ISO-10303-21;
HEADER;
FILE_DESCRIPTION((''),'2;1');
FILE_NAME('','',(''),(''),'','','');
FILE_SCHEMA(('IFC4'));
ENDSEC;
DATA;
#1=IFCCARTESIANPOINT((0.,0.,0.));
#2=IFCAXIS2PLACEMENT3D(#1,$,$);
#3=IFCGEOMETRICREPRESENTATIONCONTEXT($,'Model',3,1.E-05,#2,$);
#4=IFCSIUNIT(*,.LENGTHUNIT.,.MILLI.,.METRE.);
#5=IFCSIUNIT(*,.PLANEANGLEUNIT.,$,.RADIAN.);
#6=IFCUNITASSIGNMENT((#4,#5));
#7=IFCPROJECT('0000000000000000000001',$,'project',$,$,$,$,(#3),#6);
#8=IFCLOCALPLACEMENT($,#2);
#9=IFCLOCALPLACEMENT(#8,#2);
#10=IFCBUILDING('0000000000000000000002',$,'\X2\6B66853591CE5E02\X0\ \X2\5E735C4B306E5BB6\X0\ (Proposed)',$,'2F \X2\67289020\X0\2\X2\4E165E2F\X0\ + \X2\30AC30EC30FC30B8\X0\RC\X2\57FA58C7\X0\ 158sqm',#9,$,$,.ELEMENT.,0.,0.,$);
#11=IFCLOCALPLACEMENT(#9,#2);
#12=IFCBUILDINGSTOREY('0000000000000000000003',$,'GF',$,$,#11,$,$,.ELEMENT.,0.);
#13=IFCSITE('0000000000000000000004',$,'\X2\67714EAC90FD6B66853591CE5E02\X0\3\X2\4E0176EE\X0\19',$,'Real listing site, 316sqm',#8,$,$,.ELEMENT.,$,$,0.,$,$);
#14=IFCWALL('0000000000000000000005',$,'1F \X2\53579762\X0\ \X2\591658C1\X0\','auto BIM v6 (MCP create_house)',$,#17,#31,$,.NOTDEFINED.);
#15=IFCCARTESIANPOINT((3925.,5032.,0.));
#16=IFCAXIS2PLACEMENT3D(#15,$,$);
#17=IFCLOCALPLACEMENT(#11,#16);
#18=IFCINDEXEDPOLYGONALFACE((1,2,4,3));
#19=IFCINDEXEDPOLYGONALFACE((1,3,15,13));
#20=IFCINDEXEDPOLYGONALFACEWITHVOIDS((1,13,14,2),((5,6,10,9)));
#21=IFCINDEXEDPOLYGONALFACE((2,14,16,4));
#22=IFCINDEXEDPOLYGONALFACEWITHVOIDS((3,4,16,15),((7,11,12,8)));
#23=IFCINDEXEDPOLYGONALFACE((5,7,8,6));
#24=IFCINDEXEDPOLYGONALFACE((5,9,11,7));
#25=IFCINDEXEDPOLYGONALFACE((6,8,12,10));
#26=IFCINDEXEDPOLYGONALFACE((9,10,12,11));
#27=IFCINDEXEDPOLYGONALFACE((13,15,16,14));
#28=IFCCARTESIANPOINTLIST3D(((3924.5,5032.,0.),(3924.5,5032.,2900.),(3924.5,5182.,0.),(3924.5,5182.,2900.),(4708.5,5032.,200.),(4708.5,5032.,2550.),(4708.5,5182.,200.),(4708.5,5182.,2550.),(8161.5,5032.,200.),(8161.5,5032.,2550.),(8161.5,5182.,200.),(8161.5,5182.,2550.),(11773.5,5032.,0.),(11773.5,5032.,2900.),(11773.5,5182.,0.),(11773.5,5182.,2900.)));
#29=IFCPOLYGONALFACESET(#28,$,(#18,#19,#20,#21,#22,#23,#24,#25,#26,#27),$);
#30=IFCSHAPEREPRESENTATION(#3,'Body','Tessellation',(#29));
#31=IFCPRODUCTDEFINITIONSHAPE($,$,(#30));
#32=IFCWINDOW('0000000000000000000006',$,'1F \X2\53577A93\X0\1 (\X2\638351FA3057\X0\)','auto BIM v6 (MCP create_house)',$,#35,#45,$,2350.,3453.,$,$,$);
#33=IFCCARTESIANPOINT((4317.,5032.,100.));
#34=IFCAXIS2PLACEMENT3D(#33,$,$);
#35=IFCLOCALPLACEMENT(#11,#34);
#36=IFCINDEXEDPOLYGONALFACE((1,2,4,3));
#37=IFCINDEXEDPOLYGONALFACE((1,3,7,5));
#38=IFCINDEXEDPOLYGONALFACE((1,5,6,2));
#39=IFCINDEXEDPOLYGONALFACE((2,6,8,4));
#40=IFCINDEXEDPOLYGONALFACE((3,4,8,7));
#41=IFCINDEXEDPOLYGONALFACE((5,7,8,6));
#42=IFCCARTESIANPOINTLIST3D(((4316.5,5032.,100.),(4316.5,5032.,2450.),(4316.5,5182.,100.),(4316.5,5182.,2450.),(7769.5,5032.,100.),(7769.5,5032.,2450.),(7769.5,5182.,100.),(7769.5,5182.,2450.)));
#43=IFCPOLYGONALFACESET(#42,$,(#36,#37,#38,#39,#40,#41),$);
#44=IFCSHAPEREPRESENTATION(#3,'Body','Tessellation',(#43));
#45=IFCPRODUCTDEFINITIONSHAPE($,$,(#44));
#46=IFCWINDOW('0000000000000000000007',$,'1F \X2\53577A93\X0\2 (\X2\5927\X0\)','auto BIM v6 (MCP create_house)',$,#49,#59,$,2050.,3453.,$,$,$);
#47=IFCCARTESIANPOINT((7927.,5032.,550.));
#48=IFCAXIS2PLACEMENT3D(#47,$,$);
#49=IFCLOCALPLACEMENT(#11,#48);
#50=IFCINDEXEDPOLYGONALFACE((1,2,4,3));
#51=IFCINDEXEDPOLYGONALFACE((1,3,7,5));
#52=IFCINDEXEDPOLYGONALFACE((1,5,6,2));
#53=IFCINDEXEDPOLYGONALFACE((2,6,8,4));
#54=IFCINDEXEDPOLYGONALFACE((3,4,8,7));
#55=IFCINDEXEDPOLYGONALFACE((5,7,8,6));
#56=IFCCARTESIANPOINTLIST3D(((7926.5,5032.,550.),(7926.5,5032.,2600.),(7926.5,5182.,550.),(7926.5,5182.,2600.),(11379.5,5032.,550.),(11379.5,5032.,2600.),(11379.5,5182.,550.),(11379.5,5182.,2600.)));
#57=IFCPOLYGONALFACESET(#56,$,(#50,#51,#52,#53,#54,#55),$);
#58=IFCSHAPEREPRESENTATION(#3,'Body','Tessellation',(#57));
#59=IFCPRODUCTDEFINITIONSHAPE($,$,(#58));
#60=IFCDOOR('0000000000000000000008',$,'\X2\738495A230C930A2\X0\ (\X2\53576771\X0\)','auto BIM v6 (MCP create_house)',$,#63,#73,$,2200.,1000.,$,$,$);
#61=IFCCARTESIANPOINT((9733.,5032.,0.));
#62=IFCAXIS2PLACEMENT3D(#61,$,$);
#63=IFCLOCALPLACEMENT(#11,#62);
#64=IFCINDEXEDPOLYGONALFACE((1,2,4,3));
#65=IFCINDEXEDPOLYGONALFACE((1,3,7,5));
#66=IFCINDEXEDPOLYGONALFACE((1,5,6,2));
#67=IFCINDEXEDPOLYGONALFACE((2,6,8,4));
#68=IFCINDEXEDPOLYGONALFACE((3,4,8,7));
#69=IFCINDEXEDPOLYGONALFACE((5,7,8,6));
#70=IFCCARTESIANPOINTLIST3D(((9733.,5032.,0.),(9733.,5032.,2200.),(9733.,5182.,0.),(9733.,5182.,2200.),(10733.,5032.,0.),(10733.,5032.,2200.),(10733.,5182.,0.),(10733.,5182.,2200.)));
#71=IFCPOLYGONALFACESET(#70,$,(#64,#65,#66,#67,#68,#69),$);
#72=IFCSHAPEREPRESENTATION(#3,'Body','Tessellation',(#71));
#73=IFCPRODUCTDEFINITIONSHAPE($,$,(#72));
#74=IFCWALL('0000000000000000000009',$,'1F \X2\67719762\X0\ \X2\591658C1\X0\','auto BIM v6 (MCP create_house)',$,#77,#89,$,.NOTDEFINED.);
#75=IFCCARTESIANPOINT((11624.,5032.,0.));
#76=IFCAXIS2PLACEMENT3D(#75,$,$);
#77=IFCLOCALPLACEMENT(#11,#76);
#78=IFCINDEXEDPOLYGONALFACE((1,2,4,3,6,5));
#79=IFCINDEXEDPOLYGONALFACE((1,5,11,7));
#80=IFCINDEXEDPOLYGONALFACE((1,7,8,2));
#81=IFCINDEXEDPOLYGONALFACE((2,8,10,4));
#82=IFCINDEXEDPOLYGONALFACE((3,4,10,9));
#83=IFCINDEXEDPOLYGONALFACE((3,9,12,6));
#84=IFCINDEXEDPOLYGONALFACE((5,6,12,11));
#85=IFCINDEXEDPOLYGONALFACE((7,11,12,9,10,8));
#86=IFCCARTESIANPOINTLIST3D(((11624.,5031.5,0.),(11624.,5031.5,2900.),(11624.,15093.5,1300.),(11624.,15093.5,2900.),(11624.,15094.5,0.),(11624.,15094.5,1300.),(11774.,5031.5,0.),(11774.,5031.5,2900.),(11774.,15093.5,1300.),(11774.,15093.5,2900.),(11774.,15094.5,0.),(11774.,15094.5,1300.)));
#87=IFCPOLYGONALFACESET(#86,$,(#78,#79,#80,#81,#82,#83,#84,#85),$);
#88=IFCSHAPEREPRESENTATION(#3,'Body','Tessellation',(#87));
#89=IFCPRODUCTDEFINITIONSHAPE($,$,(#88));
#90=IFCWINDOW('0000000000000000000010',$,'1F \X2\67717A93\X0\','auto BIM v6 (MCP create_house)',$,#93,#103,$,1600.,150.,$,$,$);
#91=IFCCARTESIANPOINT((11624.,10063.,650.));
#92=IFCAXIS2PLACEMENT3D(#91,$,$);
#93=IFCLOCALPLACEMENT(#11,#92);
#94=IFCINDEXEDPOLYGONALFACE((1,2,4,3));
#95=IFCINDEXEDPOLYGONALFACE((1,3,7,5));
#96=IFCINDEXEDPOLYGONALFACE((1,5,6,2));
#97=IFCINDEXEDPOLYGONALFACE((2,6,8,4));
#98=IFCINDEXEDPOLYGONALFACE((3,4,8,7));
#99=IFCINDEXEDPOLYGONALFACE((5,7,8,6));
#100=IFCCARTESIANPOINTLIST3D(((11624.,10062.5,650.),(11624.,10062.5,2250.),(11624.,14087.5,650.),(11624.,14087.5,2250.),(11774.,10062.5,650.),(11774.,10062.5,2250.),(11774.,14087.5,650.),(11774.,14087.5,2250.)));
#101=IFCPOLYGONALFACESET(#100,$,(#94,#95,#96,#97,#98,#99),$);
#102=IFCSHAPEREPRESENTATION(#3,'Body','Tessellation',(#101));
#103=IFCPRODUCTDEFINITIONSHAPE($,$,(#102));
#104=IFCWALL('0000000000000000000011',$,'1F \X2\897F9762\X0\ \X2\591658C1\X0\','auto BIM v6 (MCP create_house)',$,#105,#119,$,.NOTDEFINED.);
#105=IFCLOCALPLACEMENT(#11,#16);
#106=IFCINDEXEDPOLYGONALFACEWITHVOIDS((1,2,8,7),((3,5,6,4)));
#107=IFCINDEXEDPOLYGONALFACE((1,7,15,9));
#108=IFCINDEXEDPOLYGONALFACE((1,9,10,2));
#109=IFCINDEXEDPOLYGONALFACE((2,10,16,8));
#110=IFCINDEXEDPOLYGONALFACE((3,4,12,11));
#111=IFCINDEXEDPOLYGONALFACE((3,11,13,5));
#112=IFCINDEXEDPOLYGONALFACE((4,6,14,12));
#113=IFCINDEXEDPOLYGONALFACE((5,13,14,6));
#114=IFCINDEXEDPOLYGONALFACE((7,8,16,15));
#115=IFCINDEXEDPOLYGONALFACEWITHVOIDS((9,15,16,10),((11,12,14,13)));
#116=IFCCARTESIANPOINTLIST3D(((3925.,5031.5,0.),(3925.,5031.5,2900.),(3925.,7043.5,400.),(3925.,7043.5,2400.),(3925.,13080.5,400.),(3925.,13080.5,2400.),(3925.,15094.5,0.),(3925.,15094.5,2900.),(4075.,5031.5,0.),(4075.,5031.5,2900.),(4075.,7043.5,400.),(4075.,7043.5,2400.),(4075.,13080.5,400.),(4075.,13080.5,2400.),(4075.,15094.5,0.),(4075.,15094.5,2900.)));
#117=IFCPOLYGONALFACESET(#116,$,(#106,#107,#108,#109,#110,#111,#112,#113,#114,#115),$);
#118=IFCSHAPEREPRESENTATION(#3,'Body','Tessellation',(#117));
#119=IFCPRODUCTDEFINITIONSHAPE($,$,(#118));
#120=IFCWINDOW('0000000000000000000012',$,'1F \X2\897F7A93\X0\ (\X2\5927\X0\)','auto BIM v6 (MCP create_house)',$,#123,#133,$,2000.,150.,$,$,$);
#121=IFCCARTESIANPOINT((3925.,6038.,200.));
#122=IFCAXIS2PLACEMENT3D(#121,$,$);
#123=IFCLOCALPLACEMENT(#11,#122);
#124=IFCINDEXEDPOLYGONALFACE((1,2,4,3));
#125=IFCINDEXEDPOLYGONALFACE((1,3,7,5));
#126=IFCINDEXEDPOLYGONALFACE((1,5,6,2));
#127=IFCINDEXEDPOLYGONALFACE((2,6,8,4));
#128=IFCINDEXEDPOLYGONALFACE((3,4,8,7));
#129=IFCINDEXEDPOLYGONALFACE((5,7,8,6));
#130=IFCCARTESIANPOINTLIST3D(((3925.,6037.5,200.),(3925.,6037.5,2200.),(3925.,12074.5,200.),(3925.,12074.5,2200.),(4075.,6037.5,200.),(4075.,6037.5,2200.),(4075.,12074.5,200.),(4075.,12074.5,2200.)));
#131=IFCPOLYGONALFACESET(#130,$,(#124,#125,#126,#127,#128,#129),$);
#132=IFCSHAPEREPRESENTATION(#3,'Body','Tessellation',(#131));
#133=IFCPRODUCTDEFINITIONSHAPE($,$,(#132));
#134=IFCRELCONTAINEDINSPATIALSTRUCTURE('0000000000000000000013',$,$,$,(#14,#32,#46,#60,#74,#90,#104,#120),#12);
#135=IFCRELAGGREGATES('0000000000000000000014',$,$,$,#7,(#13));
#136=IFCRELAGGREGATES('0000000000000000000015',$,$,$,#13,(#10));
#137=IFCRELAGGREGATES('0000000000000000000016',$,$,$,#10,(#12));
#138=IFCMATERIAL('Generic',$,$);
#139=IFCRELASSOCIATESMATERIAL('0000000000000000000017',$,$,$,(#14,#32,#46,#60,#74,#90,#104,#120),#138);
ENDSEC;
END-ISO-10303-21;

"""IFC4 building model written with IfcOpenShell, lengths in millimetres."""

from ifc_helpers import new_model, si_unit, frame, frame_2d, origin, place, context, project, spatial, rectangle, extrude, material, element, fill, save


model = new_model("IFC4")

# Units and contexts
model_context = context("Model", 3, precision=1e-05, world=origin())
ifc_project = project(units=[si_unit("LENGTHUNIT", "METRE", prefix="MILLI"), si_unit("PLANEANGLEUNIT", "RADIAN")], contexts=[model_context])

# Site, building, storey
site_placement = place(None, origin())
site = spatial("IfcSite", under=ifc_project, at=site_placement, Name="東京都武蔵野市3丁目19", ObjectType="Real listing site, 316sqm", CompositionType="ELEMENT", RefElevation=0.0)
building_placement = place(site_placement, origin())
building = spatial("IfcBuilding", under=site, at=building_placement, Name="武蔵野市 平屋の家 (Proposed)", ObjectType="2F 木造2世帯 + ガレージRC基壇 158sqm", CompositionType="ELEMENT", ElevationOfRefHeight=0.0, ElevationOfTerrain=0.0)
storey_placement = place(building_placement, origin())
storey = spatial("IfcBuildingStorey", under=building, at=storey_placement, Name="GF", CompositionType="ELEMENT", Elevation=0.0)

# Shared definitions
ifc_material = material(Name="Generic")

# Wall, openings, windows, door
wall_1_placement = place(storey_placement, frame((3925.0, 5032.0, 0.0)))
wall_1 = element("IfcWall", 1, at=wall_1_placement, inside=storey, material=ifc_material, Name="1F 南面 外壁", Description="auto BIM v6 (MCP create_house)", PredefinedType="NOTDEFINED", context=model_context, shape_type="SweptSolid", body=[
    extrude(rectangle(XDim=7849.0, YDim=150.0, at=frame_2d((3924.0, 75.0))), frame((3925.0, 5032.0, 0.0)), (0.0, 0.0, 1.0), 2900.0),
])
opening_1_placement = place(storey_placement, frame((4317.0, 5032.0, 100.0)))
opening_1 = element("IfcOpeningElement", 2, at=opening_1_placement, cuts=wall_1, PredefinedType="NOTDEFINED", context=model_context, shape_type="SweptSolid", body=[
    extrude(rectangle(XDim=3453.0, YDim=150.0, at=frame_2d((1726.0, 75.0))), frame((4317.0, 5032.0, 100.0)), (0.0, 0.0, 1.0), 2350.0),
])
opening_2_placement = place(storey_placement, frame((7927.0, 5032.0, 550.0)))
opening_2 = element("IfcOpeningElement", 3, at=opening_2_placement, cuts=wall_1, PredefinedType="NOTDEFINED", context=model_context, shape_type="SweptSolid", body=[
    extrude(rectangle(XDim=3453.0, YDim=150.0, at=frame_2d((1726.0, 75.0))), frame((7927.0, 5032.0, 550.0)), (0.0, 0.0, 1.0), 2050.0),
])
opening_3_placement = place(storey_placement, frame((9733.0, 5032.0, 0.0)))
opening_3 = element("IfcOpeningElement", 4, at=opening_3_placement, cuts=wall_1, PredefinedType="NOTDEFINED", context=model_context, shape_type="SweptSolid", body=[
    extrude(rectangle(XDim=1000.0, YDim=150.0, at=frame_2d((500.0, 75.0))), frame((9733.0, 5032.0, 0.0)), (0.0, 0.0, 1.0), 2200.0),
])
window_1_placement = place(storey_placement, frame((4317.0, 5032.0, 100.0)))
window_1 = element("IfcWindow", 5, at=window_1_placement, inside=storey, material=ifc_material, Name="1F 南窓1 (掃出し)", Description="auto BIM v6 (MCP create_house)", OverallHeight=2350.0, OverallWidth=3453.0, context=model_context, shape_type="SweptSolid", body=[
    extrude(rectangle(XDim=3453.0, YDim=150.0, at=frame_2d((1726.0, 75.0))), frame((4317.0, 5032.0, 100.0)), (0.0, 0.0, 1.0), 2350.0),
])
fill(opening_1, window_1)
window_2_placement = place(storey_placement, frame((7927.0, 5032.0, 550.0)))
window_2 = element("IfcWindow", 6, at=window_2_placement, inside=storey, material=ifc_material, Name="1F 南窓2 (大)", Description="auto BIM v6 (MCP create_house)", OverallHeight=2050.0, OverallWidth=3453.0, context=model_context, shape_type="SweptSolid", body=[
    extrude(rectangle(XDim=3453.0, YDim=150.0, at=frame_2d((1726.0, 75.0))), frame((7927.0, 5032.0, 550.0)), (0.0, 0.0, 1.0), 2050.0),
])
fill(opening_2, window_2)
door_placement = place(storey_placement, frame((9733.0, 5032.0, 0.0)))
door = element("IfcDoor", 7, at=door_placement, inside=storey, material=ifc_material, Name="玄関ドア (南東)", Description="auto BIM v6 (MCP create_house)", OverallHeight=2200.0, OverallWidth=1000.0, context=model_context, shape_type="SweptSolid", body=[
    extrude(rectangle(XDim=1000.0, YDim=150.0, at=frame_2d((500.0, 75.0))), frame((9733.0, 5032.0, 0.0)), (0.0, 0.0, 1.0), 2200.0),
])
fill(opening_3, door)

# Walls, openings, windows
wall_2_placement = place(storey_placement, frame((11624.0, 5032.0, 0.0)))
wall_2 = element("IfcWall", 8, at=wall_2_placement, inside=storey, material=ifc_material, Name="1F 東面 外壁", Description="auto BIM v6 (MCP create_house)", PredefinedType="NOTDEFINED", context=model_context, shape_type="SweptSolid", body=[
    extrude(rectangle(XDim=150.0, YDim=10063.0, at=frame_2d((75.0, 5031.0))), frame((11624.0, 5032.0, 0.0)), (0.0, 0.0, 1.0), 2900.0),
])
opening_4_placement = place(storey_placement, frame((11624.0, 10063.0, 650.0)))
opening_4 = element("IfcOpeningElement", 9, at=opening_4_placement, cuts=wall_2, PredefinedType="NOTDEFINED", context=model_context, shape_type="SweptSolid", body=[
    extrude(rectangle(XDim=150.0, YDim=4025.0, at=frame_2d((75.0, 2012.0))), frame((11624.0, 10063.0, 650.0)), (0.0, 0.0, 1.0), 1600.0),
])
window_3_placement = place(storey_placement, frame((11624.0, 10063.0, 650.0)))
window_3 = element("IfcWindow", 10, at=window_3_placement, inside=storey, material=ifc_material, Name="1F 東窓", Description="auto BIM v6 (MCP create_house)", OverallHeight=1600.0, OverallWidth=150.0, context=model_context, shape_type="SweptSolid", body=[
    extrude(rectangle(XDim=150.0, YDim=4025.0, at=frame_2d((75.0, 2012.0))), frame((11624.0, 10063.0, 650.0)), (0.0, 0.0, 1.0), 1600.0),
])
fill(opening_4, window_3)
wall_3_placement = place(storey_placement, frame((3925.0, 5032.0, 0.0)))
wall_3 = element("IfcWall", 11, at=wall_3_placement, inside=storey, material=ifc_material, Name="1F 西面 外壁", Description="auto BIM v6 (MCP create_house)", PredefinedType="NOTDEFINED", context=model_context, shape_type="SweptSolid", body=[
    extrude(rectangle(XDim=150.0, YDim=10063.0, at=frame_2d((75.0, 5031.0))), frame((3925.0, 5032.0, 0.0)), (0.0, 0.0, 1.0), 2900.0),
])
opening_5_placement = place(storey_placement, frame((3925.0, 6038.0, 200.0)))
opening_5 = element("IfcOpeningElement", 12, at=opening_5_placement, cuts=wall_3, PredefinedType="NOTDEFINED", context=model_context, shape_type="SweptSolid", body=[
    extrude(rectangle(XDim=150.0, YDim=6037.0, at=frame_2d((75.0, 3018.0))), frame((3925.0, 6038.0, 200.0)), (0.0, 0.0, 1.0), 2000.0),
])
window_4_placement = place(storey_placement, frame((3925.0, 6038.0, 200.0)))
window_4 = element("IfcWindow", 13, at=window_4_placement, inside=storey, material=ifc_material, Name="1F 西窓 (大)", Description="auto BIM v6 (MCP create_house)", OverallHeight=2000.0, OverallWidth=150.0, context=model_context, shape_type="SweptSolid", body=[
    extrude(rectangle(XDim=150.0, YDim=6037.0, at=frame_2d((75.0, 3018.0))), frame((3925.0, 6038.0, 200.0)), (0.0, 0.0, 1.0), 2000.0),
])
fill(opening_5, window_4)

save(model, "model.ifc")
